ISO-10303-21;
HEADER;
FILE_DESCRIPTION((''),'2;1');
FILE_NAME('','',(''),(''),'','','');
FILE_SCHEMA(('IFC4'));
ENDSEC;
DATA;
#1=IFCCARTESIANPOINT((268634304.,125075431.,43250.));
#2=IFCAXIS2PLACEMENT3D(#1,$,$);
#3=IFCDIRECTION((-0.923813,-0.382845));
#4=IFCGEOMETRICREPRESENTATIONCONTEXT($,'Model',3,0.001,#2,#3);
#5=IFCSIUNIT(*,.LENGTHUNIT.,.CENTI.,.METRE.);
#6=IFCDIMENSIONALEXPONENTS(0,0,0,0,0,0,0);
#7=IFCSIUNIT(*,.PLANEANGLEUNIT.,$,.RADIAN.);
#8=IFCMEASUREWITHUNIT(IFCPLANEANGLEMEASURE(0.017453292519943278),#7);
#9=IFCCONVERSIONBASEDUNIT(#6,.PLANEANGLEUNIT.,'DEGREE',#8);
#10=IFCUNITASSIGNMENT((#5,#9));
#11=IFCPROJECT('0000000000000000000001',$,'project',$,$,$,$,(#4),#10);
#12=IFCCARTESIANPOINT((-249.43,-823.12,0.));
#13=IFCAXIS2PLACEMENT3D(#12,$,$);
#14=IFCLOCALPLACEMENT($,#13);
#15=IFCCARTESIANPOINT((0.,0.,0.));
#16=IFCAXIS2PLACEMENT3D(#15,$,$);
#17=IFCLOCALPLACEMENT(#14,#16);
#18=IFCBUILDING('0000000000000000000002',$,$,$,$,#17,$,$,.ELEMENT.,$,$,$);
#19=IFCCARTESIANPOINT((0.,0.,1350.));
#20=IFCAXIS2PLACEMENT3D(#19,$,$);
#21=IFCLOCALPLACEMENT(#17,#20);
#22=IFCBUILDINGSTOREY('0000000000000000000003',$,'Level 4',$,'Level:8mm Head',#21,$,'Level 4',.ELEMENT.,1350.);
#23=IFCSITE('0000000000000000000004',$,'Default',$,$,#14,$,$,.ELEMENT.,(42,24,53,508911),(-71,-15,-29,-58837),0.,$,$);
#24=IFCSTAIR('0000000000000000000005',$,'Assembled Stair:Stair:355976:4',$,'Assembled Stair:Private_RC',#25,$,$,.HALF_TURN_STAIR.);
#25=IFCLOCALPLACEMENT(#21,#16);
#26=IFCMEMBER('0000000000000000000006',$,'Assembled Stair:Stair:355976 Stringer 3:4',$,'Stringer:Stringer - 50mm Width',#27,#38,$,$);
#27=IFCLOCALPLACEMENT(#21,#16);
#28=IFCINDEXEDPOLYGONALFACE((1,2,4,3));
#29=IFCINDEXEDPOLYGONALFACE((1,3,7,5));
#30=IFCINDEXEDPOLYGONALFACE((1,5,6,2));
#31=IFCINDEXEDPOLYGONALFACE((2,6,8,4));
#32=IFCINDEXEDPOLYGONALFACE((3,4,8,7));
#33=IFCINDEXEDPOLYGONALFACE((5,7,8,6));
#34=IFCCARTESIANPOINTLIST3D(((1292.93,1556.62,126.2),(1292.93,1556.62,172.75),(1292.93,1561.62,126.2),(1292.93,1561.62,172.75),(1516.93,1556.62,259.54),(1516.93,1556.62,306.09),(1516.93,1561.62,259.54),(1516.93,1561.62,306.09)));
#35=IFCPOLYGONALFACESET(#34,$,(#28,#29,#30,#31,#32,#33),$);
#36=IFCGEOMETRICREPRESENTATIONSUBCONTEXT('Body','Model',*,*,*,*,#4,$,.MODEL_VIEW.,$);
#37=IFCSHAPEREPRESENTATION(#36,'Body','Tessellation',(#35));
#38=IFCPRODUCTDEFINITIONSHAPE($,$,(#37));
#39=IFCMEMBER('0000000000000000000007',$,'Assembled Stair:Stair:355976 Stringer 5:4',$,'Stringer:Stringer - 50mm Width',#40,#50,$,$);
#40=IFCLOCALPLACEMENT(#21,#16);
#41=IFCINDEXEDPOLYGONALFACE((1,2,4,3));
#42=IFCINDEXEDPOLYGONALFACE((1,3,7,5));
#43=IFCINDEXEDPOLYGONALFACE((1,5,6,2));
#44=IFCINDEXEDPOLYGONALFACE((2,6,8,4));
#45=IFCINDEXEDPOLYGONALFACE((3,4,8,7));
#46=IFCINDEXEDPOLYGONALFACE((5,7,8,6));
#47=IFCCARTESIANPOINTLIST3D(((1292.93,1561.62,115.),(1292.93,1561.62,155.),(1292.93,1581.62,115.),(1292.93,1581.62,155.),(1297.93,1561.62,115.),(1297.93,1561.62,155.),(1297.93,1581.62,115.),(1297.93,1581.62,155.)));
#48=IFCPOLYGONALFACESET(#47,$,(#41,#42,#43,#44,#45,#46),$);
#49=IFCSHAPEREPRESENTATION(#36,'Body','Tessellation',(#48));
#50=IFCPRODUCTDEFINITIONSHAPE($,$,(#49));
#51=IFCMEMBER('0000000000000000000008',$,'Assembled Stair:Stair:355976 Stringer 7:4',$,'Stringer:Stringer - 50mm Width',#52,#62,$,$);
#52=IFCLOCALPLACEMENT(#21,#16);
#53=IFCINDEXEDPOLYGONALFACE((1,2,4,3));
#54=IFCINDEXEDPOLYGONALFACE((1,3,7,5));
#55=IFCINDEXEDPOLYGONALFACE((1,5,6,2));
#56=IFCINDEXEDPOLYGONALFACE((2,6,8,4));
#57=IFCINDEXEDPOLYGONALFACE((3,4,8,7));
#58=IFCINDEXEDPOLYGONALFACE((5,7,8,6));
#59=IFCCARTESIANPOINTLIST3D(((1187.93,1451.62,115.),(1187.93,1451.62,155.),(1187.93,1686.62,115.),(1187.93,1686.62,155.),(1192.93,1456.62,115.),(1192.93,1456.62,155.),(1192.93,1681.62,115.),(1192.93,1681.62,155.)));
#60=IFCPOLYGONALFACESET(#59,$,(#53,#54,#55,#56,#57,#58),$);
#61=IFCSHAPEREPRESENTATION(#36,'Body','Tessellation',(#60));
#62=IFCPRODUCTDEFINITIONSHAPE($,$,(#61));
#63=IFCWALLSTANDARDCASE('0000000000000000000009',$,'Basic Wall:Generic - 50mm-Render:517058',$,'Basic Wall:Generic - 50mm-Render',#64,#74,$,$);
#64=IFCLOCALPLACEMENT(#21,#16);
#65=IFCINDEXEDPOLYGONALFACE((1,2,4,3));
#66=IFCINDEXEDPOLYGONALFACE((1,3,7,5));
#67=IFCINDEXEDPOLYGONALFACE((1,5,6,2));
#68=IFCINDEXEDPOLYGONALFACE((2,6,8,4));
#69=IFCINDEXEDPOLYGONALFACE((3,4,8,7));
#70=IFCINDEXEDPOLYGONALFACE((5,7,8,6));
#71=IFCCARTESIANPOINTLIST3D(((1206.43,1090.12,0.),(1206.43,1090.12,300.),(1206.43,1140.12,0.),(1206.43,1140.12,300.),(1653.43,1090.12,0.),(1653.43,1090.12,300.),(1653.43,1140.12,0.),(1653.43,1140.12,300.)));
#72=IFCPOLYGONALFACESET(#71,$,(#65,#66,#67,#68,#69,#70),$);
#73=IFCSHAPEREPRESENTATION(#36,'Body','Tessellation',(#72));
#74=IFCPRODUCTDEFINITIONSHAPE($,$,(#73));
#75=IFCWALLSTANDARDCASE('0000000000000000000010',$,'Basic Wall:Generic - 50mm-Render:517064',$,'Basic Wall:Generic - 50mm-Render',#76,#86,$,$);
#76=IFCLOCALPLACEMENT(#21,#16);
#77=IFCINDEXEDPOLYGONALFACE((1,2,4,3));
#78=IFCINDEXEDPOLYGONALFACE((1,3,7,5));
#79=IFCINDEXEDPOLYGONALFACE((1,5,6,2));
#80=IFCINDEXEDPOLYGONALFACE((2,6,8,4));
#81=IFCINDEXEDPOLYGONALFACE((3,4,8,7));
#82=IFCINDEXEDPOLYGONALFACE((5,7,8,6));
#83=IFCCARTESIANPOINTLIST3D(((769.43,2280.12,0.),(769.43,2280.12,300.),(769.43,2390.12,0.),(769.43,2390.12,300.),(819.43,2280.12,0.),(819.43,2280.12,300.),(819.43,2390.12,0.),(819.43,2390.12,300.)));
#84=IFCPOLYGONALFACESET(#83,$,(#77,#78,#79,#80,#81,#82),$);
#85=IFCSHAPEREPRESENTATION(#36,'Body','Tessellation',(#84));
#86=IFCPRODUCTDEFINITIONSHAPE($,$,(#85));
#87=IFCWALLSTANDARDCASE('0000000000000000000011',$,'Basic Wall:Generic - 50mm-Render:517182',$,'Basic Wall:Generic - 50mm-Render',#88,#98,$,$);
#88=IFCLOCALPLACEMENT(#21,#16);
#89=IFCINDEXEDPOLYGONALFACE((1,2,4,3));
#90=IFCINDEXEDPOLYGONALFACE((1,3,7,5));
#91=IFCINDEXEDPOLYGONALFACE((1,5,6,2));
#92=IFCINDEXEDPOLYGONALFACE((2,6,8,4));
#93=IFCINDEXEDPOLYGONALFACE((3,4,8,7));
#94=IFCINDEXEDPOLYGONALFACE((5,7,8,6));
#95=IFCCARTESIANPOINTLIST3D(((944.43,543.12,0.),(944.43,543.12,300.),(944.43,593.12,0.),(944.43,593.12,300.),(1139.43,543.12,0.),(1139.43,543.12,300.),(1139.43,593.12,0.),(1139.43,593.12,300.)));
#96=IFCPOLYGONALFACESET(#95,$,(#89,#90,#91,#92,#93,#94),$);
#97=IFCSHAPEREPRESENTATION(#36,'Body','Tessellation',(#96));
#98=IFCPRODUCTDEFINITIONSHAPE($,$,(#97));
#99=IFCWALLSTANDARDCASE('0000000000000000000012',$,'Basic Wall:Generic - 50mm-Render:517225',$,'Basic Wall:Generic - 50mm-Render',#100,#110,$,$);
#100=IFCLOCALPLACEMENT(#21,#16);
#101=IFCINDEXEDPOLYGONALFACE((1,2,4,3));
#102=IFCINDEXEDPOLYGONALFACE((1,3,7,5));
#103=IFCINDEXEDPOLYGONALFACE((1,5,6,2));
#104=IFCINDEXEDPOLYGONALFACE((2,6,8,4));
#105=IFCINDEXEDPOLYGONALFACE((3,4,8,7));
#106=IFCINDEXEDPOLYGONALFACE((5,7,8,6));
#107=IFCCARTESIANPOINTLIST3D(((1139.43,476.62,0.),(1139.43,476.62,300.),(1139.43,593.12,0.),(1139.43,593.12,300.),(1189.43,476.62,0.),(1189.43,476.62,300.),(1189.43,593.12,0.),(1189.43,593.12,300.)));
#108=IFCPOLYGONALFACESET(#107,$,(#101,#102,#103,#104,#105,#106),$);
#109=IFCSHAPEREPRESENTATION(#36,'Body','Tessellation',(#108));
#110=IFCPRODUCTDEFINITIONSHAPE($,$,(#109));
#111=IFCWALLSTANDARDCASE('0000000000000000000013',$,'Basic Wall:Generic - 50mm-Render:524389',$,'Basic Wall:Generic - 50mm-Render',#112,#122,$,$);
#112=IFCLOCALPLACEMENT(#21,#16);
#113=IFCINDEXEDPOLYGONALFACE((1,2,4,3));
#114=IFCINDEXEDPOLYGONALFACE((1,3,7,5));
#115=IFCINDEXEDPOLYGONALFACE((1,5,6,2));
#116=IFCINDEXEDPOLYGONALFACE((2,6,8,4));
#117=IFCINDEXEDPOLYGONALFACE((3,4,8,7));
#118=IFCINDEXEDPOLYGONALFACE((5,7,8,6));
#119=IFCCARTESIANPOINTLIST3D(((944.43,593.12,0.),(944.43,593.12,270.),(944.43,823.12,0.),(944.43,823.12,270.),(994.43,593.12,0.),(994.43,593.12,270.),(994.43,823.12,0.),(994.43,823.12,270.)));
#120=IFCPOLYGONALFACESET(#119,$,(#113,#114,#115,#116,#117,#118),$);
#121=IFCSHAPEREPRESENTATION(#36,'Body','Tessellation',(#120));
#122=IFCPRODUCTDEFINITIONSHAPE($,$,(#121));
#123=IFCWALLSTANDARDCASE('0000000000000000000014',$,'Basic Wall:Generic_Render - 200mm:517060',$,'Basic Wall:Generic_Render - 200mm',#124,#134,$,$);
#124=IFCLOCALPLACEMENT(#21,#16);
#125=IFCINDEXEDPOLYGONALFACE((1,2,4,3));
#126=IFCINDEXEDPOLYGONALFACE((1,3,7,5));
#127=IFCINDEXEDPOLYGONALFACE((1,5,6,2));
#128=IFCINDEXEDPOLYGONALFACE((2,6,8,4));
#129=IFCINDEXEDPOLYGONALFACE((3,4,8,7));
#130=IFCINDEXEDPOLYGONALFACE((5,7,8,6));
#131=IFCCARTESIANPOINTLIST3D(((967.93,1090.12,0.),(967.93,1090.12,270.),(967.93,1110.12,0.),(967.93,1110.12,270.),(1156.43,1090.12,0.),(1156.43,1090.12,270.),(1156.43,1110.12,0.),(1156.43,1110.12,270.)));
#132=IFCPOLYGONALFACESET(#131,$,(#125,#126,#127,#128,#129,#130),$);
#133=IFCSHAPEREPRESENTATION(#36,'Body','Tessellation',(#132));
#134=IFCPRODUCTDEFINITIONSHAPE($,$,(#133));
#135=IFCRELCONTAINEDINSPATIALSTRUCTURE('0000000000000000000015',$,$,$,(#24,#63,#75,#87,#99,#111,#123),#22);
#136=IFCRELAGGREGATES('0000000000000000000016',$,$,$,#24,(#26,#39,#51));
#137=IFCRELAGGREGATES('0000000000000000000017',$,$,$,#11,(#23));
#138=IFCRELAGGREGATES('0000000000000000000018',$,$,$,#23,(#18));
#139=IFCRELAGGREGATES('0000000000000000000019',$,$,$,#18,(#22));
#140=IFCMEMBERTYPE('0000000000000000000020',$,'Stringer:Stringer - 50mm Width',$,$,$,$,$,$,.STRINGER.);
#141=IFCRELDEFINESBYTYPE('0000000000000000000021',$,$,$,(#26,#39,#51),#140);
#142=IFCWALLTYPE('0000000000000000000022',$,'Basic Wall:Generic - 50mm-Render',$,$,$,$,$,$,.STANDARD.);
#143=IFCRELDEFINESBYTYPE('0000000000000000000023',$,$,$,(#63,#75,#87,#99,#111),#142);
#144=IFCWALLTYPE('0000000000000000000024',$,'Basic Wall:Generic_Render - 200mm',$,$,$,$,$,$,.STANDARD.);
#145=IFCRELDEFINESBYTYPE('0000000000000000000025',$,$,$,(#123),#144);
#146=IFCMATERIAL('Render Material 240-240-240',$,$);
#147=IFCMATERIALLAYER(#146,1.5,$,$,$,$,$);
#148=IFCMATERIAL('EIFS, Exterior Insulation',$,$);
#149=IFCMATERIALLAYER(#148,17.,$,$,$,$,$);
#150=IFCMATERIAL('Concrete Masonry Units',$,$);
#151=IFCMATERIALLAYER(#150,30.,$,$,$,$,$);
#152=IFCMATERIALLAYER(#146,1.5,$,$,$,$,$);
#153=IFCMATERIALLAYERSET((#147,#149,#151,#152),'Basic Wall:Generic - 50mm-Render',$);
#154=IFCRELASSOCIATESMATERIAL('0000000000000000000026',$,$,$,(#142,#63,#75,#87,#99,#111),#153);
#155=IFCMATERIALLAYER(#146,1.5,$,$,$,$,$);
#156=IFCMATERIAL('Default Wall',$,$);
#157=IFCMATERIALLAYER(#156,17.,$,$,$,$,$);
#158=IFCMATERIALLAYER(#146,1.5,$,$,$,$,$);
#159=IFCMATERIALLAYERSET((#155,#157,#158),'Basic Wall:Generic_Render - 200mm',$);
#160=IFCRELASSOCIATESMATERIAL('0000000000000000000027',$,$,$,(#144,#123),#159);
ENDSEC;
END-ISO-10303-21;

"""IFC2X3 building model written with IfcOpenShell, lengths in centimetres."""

from ifc_helpers import new_model, entity, si_unit, converted_unit, direction, frame, frame_2d, origin, place, context, subcontext, project, spatial, polyline, rectangle, outline, extrude, material, layer, layer_set, layer_usage, type_object, element, aggregate, save


model = new_model("IFC2X3")

# Units and contexts
model_context = context("Model", 3, precision=0.001, world=frame((268634304.0, 125075431.0, 43250.0)), true_north=direction((-0.923813, -0.382845)))
body_context = subcontext(model_context, "Body", "Model", "MODEL_VIEW")
ifc_project = project(units=[si_unit("LENGTHUNIT", "METRE", prefix="CENTI"), converted_unit("PLANEANGLEUNIT", "DEGREE", entity("IfcPlaneAngleMeasure", 0.017453292519943278), si_unit("PLANEANGLEUNIT", "RADIAN"), dimensions=[0, 0, 0, 0, 0, 0, 0])], contexts=[model_context])

# Site, building, storey
site_placement = place(None, frame((-249.43, -823.12, 0.0)))
site = spatial("IfcSite", under=ifc_project, at=site_placement, Name="Default", CompositionType="ELEMENT", RefLatitude=(42, 24, 53, 508911), RefLongitude=(-71, -15, -29, -58837), RefElevation=0.0)
building_placement = place(site_placement, origin())
building = spatial("IfcBuilding", under=site, at=building_placement, CompositionType="ELEMENT")
storey_placement = place(building_placement, frame((0.0, 0.0, 1350.0)))
storey = spatial("IfcBuildingStorey", under=building, at=storey_placement, Name="Level 4", ObjectType="Level:8mm Head", LongName="Level 4", CompositionType="ELEMENT", Elevation=1350.0)

# Stair, members
stair_placement = place(storey_placement, origin())
stair = element("IfcStair", 1, at=stair_placement, inside=storey, Name="Assembled Stair:Stair:355976:4", ObjectType="Assembled Stair:Private_RC", ShapeType="HALF_TURN_STAIR")
member_type = type_object("IfcMemberType", Name="Stringer:Stringer - 50mm Width", PredefinedType="STRINGER")
member_1_placement = place(stair_placement, frame((1292.93, 1556.62, 126.2)))
member_1 = element("IfcMember", 2, at=member_1_placement, type_object=member_type, Name="Assembled Stair:Stair:355976 Stringer 3:4", ObjectType="Stringer:Stringer - 50mm Width", context=body_context, shape_type="SweptSolid", body=[
    extrude(outline(polyline([(-118.43, -20.0), (142.24, -20.0), (118.43, 20.0), (-142.24, 20.0), (-118.43, -20.0)])), frame((112.0, 0.0, 89.94), z_axis=(0.0, 1.0, 0.0), x_axis=(0.859293, 0.0, 0.511484)), (0.0, 0.0, 1.0), 5.0),
])
member_2_placement = place(stair_placement, frame((1292.93, 1561.62, 115.0)))
member_2 = element("IfcMember", 3, at=member_2_placement, type_object=member_type, Name="Assembled Stair:Stair:355976 Stringer 5:4", ObjectType="Stringer:Stringer - 50mm Width", context=body_context, shape_type="SweptSolid", body=[
    extrude(rectangle(XDim=20.0, YDim=5.0, at=frame_2d((0.0, 0.0), x_axis=(1.0, 0.0))), frame((2.5, 10.0, 0.0), z_axis=(0.0, 0.0, 1.0), x_axis=(0.0, 1.0, 0.0)), (0.0, 0.0, 1.0), 40.0),
])
member_3_placement = place(stair_placement, frame((1187.93, 1451.62, 115.0)))
member_3 = element("IfcMember", 4, at=member_3_placement, type_object=member_type, Name="Assembled Stair:Stair:355976 Stringer 7:4", ObjectType="Stringer:Stringer - 50mm Width", context=body_context, shape_type="SweptSolid", body=[
    extrude(outline(polyline([(-117.5, -2.5), (117.5, -2.5), (112.5, 2.5), (-112.5, 2.5), (-117.5, -2.5)])), frame((2.5, 117.5, 0.0), z_axis=(0.0, 0.0, 1.0), x_axis=(0.0, -1.0, 0.0)), (0.0, 0.0, 1.0), 40.0),
])
aggregate(stair, [member_1, member_2, member_3])

# Walls
ifc_material_1 = material(Name="Render Material 240-240-240")
ifc_layer_1 = layer(ifc_material_1, 1.5)
ifc_material_2 = material(Name="EIFS, Exterior Insulation")
ifc_layer_2 = layer(ifc_material_2, 17.0)
ifc_material_3 = material(Name="Concrete Masonry Units")
ifc_layer_3 = layer(ifc_material_3, 30.0)
ifc_layer_4 = layer(ifc_material_1, 1.5)
ifc_layer_set_1 = layer_set([ifc_layer_1, ifc_layer_2, ifc_layer_3, ifc_layer_4], Name="Basic Wall:Generic - 50mm-Render")
ifc_layer_usage_1 = layer_usage(ifc_layer_set_1, "AXIS2", "NEGATIVE", 25.0)
wall_type_1 = type_object("IfcWallType", Name="Basic Wall:Generic - 50mm-Render", PredefinedType="STANDARD", material=ifc_layer_set_1)
wall_1_placement = place(storey_placement, frame((1206.43, 1115.12, 0.0)))
element("IfcWallStandardCase", 5, at=wall_1_placement, inside=storey, type_object=wall_type_1, material=ifc_layer_usage_1, Name="Basic Wall:Generic - 50mm-Render:517058", ObjectType="Basic Wall:Generic - 50mm-Render", context=body_context, shape_type="SweptSolid", body=[
    extrude(rectangle(XDim=447.0, YDim=50.0, at=frame_2d((223.5, 0.0), x_axis=(-1.0, 0.0))), origin(), (0.0, 0.0, 1.0), 300.0),
])
ifc_layer_usage_2 = layer_usage(ifc_layer_set_1, "AXIS2", "NEGATIVE", 25.0)
wall_2_placement = place(storey_placement, frame((794.43, 2280.12, 0.0), z_axis=(0.0, 0.0, 1.0), x_axis=(0.0, 1.0, 0.0)))
element("IfcWallStandardCase", 6, at=wall_2_placement, inside=storey, type_object=wall_type_1, material=ifc_layer_usage_2, Name="Basic Wall:Generic - 50mm-Render:517064", ObjectType="Basic Wall:Generic - 50mm-Render", context=body_context, shape_type="SweptSolid", body=[
    extrude(rectangle(XDim=110.0, YDim=50.0, at=frame_2d((55.0, 0.0), x_axis=(-1.0, 0.0))), origin(), (0.0, 0.0, 1.0), 300.0),
])
ifc_layer_usage_3 = layer_usage(ifc_layer_set_1, "AXIS2", "NEGATIVE", 25.0)
wall_3_placement = place(storey_placement, frame((1139.43, 568.12, 0.0), z_axis=(0.0, 0.0, 1.0), x_axis=(-1.0, 0.0, 0.0)))
element("IfcWallStandardCase", 7, at=wall_3_placement, inside=storey, type_object=wall_type_1, material=ifc_layer_usage_3, Name="Basic Wall:Generic - 50mm-Render:517182", ObjectType="Basic Wall:Generic - 50mm-Render", context=body_context, shape_type="SweptSolid", body=[
    extrude(rectangle(XDim=195.0, YDim=50.0, at=frame_2d((97.5, 0.0), x_axis=(-1.0, 0.0))), origin(), (0.0, 0.0, 1.0), 300.0),
])
ifc_layer_usage_4 = layer_usage(ifc_layer_set_1, "AXIS2", "POSITIVE", -25.0)
wall_4_placement = place(storey_placement, frame((1164.43, 593.12, 0.0), z_axis=(0.0, 0.0, 1.0), x_axis=(0.0, -1.0, 0.0)))
element("IfcWallStandardCase", 8, at=wall_4_placement, inside=storey, type_object=wall_type_1, material=ifc_layer_usage_4, Name="Basic Wall:Generic - 50mm-Render:517225", ObjectType="Basic Wall:Generic - 50mm-Render", context=body_context, shape_type="SweptSolid", body=[
    extrude(rectangle(XDim=116.5, YDim=50.0, at=frame_2d((58.25, 0.0), x_axis=(-1.0, 0.0))), origin(), (0.0, 0.0, 1.0), 300.0),
])
ifc_layer_usage_5 = layer_usage(ifc_layer_set_1, "AXIS2", "POSITIVE", -25.0)
wall_5_placement = place(storey_placement, frame((969.43, 823.12, 0.0), z_axis=(0.0, 0.0, 1.0), x_axis=(0.0, -1.0, 0.0)))
element("IfcWallStandardCase", 9, at=wall_5_placement, inside=storey, type_object=wall_type_1, material=ifc_layer_usage_5, Name="Basic Wall:Generic - 50mm-Render:524389", ObjectType="Basic Wall:Generic - 50mm-Render", context=body_context, shape_type="SweptSolid", body=[
    extrude(rectangle(XDim=230.0, YDim=50.0, at=frame_2d((115.0, 0.0), x_axis=(-1.0, 0.0))), origin(), (0.0, 0.0, 1.0), 270.0),
])
ifc_layer_5 = layer(ifc_material_1, 1.5)
ifc_material_4 = material(Name="Default Wall")
ifc_layer_6 = layer(ifc_material_4, 17.0)
ifc_layer_7 = layer(ifc_material_1, 1.5)
ifc_layer_set_2 = layer_set([ifc_layer_5, ifc_layer_6, ifc_layer_7], Name="Basic Wall:Generic_Render - 200mm")
ifc_layer_usage_6 = layer_usage(ifc_layer_set_2, "AXIS2", "NEGATIVE", 10.0)
wall_type_2 = type_object("IfcWallType", Name="Basic Wall:Generic_Render - 200mm", PredefinedType="STANDARD", material=ifc_layer_set_2)
wall_6_placement = place(storey_placement, frame((1156.43, 1100.12, 0.0), z_axis=(0.0, 0.0, 1.0), x_axis=(-1.0, 0.0, 0.0)))
element("IfcWallStandardCase", 10, at=wall_6_placement, inside=storey, type_object=wall_type_2, material=ifc_layer_usage_6, Name="Basic Wall:Generic_Render - 200mm:517060", ObjectType="Basic Wall:Generic_Render - 200mm", context=body_context, shape_type="SweptSolid", body=[
    extrude(rectangle(XDim=188.5, YDim=20.0, at=frame_2d((94.25, 0.0), x_axis=(-1.0, 0.0))), origin(), (0.0, 0.0, 1.0), 270.0),
])

save(model, "model.ifc")
